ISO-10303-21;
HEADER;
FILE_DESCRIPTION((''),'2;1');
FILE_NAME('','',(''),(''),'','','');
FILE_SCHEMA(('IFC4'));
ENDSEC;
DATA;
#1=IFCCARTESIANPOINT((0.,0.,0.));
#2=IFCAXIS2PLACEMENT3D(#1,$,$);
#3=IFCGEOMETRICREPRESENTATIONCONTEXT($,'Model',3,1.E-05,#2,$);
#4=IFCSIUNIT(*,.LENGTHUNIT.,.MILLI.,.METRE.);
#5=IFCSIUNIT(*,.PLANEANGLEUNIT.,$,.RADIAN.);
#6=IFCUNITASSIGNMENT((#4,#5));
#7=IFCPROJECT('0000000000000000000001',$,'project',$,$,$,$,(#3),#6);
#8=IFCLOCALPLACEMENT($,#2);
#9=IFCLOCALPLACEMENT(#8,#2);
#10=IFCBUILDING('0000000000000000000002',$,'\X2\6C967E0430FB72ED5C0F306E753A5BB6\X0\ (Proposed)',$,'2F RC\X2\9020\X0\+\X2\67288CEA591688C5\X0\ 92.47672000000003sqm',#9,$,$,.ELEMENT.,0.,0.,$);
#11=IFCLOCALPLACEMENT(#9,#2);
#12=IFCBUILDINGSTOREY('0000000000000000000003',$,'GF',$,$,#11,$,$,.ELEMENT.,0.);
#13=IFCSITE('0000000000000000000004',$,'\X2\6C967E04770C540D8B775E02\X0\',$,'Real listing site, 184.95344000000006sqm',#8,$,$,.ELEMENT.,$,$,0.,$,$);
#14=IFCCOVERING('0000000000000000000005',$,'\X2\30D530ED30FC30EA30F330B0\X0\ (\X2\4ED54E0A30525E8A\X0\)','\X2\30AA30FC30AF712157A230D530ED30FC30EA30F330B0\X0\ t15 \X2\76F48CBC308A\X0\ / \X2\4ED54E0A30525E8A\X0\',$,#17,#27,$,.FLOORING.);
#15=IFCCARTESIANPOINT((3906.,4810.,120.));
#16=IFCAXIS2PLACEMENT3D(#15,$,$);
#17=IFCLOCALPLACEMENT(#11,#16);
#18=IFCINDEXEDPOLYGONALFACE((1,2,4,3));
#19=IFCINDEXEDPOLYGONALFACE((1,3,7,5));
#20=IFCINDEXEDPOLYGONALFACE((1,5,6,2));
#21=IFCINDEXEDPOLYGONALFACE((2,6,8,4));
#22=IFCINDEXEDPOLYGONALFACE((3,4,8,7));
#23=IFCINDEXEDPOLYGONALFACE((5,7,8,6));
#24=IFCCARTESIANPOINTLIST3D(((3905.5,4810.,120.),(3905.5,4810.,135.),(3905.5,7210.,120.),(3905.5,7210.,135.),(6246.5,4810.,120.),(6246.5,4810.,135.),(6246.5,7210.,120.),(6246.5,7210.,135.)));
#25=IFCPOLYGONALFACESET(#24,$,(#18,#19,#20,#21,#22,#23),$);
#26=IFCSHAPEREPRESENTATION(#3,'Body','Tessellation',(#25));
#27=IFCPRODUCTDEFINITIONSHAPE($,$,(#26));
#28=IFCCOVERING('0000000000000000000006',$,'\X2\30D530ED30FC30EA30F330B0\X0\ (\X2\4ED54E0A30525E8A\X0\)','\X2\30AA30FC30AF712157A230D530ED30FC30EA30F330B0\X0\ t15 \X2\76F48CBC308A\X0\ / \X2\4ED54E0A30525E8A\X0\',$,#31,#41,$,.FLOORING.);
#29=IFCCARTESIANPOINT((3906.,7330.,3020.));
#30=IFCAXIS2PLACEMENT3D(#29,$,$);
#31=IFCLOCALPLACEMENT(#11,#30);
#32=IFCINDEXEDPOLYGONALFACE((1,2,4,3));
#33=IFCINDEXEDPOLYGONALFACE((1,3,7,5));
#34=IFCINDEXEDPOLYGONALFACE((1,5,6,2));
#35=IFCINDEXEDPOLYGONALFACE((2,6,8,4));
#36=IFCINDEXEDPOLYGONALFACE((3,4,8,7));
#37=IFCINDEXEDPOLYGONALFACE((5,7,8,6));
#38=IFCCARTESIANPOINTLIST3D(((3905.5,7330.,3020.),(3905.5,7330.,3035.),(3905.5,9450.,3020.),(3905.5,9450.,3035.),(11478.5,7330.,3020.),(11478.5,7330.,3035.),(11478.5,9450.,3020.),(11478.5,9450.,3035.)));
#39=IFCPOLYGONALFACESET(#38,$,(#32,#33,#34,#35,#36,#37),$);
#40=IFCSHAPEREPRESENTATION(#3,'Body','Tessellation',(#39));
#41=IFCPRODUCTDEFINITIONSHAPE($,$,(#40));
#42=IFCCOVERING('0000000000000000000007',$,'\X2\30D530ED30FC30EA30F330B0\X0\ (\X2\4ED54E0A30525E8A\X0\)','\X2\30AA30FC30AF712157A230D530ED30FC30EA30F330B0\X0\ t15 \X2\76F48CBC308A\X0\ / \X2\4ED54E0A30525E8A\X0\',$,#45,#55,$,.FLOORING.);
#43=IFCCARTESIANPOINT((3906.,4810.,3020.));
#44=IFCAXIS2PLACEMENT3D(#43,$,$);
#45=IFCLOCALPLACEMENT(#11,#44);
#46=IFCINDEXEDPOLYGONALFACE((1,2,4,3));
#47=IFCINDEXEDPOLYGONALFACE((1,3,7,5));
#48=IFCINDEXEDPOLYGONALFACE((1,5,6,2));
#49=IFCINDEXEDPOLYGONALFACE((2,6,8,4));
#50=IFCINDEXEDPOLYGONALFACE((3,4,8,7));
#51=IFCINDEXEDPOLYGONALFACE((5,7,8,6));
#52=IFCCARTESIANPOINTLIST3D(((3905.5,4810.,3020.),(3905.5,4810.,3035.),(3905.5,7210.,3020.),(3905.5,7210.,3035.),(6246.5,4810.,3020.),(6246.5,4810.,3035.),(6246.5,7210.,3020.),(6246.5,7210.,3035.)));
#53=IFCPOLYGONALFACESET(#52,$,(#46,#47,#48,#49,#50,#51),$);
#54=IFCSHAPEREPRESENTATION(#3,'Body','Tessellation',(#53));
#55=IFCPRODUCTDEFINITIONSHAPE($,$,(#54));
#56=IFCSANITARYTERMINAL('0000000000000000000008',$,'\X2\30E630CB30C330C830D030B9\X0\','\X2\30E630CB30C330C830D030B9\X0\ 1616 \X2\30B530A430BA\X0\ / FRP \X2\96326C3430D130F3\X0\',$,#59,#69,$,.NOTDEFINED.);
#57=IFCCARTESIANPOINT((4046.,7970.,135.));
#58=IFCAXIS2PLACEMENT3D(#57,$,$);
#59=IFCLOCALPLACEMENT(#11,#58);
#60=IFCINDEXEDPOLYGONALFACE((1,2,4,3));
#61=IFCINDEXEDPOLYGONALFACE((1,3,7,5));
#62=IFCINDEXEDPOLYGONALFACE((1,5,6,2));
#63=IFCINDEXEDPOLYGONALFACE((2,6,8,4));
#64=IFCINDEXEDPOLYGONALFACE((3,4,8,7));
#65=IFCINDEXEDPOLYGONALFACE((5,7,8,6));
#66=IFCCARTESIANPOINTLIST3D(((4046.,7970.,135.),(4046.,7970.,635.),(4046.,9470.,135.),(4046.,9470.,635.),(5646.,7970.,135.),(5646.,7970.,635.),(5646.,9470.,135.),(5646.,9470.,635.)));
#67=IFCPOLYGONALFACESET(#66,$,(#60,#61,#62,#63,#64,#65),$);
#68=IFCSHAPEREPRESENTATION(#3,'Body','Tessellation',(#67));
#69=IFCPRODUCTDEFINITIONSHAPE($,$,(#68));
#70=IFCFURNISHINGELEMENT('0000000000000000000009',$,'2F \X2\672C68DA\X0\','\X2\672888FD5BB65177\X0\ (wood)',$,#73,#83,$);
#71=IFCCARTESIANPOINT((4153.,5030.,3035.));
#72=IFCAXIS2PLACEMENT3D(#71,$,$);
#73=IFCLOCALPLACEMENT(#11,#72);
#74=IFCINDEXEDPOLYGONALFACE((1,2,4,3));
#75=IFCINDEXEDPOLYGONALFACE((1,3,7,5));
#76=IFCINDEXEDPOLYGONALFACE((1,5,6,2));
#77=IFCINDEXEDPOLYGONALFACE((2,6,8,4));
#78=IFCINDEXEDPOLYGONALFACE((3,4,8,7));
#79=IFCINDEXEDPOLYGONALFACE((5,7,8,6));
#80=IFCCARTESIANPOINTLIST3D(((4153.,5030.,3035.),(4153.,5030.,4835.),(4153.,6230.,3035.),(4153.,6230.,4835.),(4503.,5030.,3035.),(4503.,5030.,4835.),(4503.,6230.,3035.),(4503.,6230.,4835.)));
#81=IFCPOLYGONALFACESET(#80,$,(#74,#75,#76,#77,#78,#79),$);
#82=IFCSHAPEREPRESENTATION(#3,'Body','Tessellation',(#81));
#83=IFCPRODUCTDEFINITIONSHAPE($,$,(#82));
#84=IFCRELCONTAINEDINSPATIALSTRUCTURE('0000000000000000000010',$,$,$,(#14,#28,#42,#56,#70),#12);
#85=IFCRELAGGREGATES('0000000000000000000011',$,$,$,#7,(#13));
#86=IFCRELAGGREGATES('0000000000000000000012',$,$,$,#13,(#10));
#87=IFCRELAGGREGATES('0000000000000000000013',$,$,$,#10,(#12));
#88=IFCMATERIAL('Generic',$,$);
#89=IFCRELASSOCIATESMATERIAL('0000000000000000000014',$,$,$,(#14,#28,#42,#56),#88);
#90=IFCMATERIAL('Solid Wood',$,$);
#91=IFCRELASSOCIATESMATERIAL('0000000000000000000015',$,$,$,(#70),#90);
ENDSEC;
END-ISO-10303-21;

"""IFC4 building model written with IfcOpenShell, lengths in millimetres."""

from ifc_helpers import new_model, si_unit, frame, frame_2d, origin, place, context, project, spatial, rectangle, extrude, material, element, save


model = new_model("IFC4")

# Units and contexts
model_context = context("Model", 3, precision=1e-05, world=origin())
ifc_project = project(units=[si_unit("LENGTHUNIT", "METRE", prefix="MILLI"), si_unit("PLANEANGLEUNIT", "RADIAN")], contexts=[model_context])

# Site, building, storey
site_placement = place(None, origin())
site = spatial("IfcSite", under=ifc_project, at=site_placement, Name="沖縄県名護市", ObjectType="Real listing site, 184.95344000000006sqm", CompositionType="ELEMENT", RefElevation=0.0)
building_placement = place(site_placement, origin())
building = spatial("IfcBuilding", under=site, at=building_placement, Name="沖縄・狭小の町家 (Proposed)", ObjectType="2F RC造+木質外装 92.47672000000003sqm", CompositionType="ELEMENT", ElevationOfRefHeight=0.0, ElevationOfTerrain=0.0)
storey_placement = place(building_placement, origin())
storey = spatial("IfcBuildingStorey", under=building, at=storey_placement, Name="GF", CompositionType="ELEMENT", Elevation=0.0)

# Shared definitions
ifc_material_1 = material(Name="Solid Wood")

# Coverings
ifc_material_2 = material(Name="Generic")
covering_1_placement = place(storey_placement, frame((3906.0, 4810.0, 120.0)))
element("IfcCovering", 1, at=covering_1_placement, inside=storey, material=ifc_material_2, Name="フローリング (仕上げ床)", Description="オーク無垢フローリング t15 直貼り / 仕上げ床", PredefinedType="FLOORING", context=model_context, shape_type="SweptSolid", body=[
    extrude(rectangle(XDim=2341.0, YDim=2400.0, at=frame_2d((1170.0, 1200.0))), frame((3906.0, 4810.0, 120.0)), (0.0, 0.0, 1.0), 15.0),
])
covering_2_placement = place(storey_placement, frame((3906.0, 7330.0, 3020.0)))
element("IfcCovering", 2, at=covering_2_placement, inside=storey, material=ifc_material_2, Name="フローリング (仕上げ床)", Description="オーク無垢フローリング t15 直貼り / 仕上げ床", PredefinedType="FLOORING", context=model_context, shape_type="SweptSolid", body=[
    extrude(rectangle(XDim=7573.0, YDim=2120.0, at=frame_2d((3786.0, 1060.0))), frame((3906.0, 7330.0, 3020.0)), (0.0, 0.0, 1.0), 15.0),
])
covering_3_placement = place(storey_placement, frame((3906.0, 4810.0, 3020.0)))
element("IfcCovering", 3, at=covering_3_placement, inside=storey, material=ifc_material_2, Name="フローリング (仕上げ床)", Description="オーク無垢フローリング t15 直貼り / 仕上げ床", PredefinedType="FLOORING", context=model_context, shape_type="SweptSolid", body=[
    extrude(rectangle(XDim=2341.0, YDim=2400.0, at=frame_2d((1170.0, 1200.0))), frame((3906.0, 4810.0, 3020.0)), (0.0, 0.0, 1.0), 15.0),
])

# Sanitary terminal
sanitary_terminal_placement = place(storey_placement, frame((4046.0, 7970.0, 135.0)))
element("IfcSanitaryTerminal", 4, at=sanitary_terminal_placement, inside=storey, material=ifc_material_2, Name="ユニットバス", Description="ユニットバス 1616 サイズ / FRP 防水パン", PredefinedType="NOTDEFINED", context=model_context, shape_type="SweptSolid", body=[
    extrude(rectangle(XDim=1600.0, YDim=1500.0, at=frame_2d((800.0, 750.0))), frame((4046.0, 7970.0, 135.0)), (0.0, 0.0, 1.0), 500.0),
])

# Furnishing element
furnishing_placement = place(storey_placement, frame((4153.0, 5030.0, 3035.0)))
element("IfcFurnishingElement", 5, at=furnishing_placement, inside=storey, material=ifc_material_1, Name="2F 本棚", Description="木製家具 (wood)", context=model_context, shape_type="SweptSolid", body=[
    extrude(rectangle(XDim=350.0, YDim=1200.0, at=frame_2d((175.0, 600.0))), frame((4153.0, 5030.0, 3035.0)), (0.0, 0.0, 1.0), 1800.0),
])

save(model, "model.ifc")
